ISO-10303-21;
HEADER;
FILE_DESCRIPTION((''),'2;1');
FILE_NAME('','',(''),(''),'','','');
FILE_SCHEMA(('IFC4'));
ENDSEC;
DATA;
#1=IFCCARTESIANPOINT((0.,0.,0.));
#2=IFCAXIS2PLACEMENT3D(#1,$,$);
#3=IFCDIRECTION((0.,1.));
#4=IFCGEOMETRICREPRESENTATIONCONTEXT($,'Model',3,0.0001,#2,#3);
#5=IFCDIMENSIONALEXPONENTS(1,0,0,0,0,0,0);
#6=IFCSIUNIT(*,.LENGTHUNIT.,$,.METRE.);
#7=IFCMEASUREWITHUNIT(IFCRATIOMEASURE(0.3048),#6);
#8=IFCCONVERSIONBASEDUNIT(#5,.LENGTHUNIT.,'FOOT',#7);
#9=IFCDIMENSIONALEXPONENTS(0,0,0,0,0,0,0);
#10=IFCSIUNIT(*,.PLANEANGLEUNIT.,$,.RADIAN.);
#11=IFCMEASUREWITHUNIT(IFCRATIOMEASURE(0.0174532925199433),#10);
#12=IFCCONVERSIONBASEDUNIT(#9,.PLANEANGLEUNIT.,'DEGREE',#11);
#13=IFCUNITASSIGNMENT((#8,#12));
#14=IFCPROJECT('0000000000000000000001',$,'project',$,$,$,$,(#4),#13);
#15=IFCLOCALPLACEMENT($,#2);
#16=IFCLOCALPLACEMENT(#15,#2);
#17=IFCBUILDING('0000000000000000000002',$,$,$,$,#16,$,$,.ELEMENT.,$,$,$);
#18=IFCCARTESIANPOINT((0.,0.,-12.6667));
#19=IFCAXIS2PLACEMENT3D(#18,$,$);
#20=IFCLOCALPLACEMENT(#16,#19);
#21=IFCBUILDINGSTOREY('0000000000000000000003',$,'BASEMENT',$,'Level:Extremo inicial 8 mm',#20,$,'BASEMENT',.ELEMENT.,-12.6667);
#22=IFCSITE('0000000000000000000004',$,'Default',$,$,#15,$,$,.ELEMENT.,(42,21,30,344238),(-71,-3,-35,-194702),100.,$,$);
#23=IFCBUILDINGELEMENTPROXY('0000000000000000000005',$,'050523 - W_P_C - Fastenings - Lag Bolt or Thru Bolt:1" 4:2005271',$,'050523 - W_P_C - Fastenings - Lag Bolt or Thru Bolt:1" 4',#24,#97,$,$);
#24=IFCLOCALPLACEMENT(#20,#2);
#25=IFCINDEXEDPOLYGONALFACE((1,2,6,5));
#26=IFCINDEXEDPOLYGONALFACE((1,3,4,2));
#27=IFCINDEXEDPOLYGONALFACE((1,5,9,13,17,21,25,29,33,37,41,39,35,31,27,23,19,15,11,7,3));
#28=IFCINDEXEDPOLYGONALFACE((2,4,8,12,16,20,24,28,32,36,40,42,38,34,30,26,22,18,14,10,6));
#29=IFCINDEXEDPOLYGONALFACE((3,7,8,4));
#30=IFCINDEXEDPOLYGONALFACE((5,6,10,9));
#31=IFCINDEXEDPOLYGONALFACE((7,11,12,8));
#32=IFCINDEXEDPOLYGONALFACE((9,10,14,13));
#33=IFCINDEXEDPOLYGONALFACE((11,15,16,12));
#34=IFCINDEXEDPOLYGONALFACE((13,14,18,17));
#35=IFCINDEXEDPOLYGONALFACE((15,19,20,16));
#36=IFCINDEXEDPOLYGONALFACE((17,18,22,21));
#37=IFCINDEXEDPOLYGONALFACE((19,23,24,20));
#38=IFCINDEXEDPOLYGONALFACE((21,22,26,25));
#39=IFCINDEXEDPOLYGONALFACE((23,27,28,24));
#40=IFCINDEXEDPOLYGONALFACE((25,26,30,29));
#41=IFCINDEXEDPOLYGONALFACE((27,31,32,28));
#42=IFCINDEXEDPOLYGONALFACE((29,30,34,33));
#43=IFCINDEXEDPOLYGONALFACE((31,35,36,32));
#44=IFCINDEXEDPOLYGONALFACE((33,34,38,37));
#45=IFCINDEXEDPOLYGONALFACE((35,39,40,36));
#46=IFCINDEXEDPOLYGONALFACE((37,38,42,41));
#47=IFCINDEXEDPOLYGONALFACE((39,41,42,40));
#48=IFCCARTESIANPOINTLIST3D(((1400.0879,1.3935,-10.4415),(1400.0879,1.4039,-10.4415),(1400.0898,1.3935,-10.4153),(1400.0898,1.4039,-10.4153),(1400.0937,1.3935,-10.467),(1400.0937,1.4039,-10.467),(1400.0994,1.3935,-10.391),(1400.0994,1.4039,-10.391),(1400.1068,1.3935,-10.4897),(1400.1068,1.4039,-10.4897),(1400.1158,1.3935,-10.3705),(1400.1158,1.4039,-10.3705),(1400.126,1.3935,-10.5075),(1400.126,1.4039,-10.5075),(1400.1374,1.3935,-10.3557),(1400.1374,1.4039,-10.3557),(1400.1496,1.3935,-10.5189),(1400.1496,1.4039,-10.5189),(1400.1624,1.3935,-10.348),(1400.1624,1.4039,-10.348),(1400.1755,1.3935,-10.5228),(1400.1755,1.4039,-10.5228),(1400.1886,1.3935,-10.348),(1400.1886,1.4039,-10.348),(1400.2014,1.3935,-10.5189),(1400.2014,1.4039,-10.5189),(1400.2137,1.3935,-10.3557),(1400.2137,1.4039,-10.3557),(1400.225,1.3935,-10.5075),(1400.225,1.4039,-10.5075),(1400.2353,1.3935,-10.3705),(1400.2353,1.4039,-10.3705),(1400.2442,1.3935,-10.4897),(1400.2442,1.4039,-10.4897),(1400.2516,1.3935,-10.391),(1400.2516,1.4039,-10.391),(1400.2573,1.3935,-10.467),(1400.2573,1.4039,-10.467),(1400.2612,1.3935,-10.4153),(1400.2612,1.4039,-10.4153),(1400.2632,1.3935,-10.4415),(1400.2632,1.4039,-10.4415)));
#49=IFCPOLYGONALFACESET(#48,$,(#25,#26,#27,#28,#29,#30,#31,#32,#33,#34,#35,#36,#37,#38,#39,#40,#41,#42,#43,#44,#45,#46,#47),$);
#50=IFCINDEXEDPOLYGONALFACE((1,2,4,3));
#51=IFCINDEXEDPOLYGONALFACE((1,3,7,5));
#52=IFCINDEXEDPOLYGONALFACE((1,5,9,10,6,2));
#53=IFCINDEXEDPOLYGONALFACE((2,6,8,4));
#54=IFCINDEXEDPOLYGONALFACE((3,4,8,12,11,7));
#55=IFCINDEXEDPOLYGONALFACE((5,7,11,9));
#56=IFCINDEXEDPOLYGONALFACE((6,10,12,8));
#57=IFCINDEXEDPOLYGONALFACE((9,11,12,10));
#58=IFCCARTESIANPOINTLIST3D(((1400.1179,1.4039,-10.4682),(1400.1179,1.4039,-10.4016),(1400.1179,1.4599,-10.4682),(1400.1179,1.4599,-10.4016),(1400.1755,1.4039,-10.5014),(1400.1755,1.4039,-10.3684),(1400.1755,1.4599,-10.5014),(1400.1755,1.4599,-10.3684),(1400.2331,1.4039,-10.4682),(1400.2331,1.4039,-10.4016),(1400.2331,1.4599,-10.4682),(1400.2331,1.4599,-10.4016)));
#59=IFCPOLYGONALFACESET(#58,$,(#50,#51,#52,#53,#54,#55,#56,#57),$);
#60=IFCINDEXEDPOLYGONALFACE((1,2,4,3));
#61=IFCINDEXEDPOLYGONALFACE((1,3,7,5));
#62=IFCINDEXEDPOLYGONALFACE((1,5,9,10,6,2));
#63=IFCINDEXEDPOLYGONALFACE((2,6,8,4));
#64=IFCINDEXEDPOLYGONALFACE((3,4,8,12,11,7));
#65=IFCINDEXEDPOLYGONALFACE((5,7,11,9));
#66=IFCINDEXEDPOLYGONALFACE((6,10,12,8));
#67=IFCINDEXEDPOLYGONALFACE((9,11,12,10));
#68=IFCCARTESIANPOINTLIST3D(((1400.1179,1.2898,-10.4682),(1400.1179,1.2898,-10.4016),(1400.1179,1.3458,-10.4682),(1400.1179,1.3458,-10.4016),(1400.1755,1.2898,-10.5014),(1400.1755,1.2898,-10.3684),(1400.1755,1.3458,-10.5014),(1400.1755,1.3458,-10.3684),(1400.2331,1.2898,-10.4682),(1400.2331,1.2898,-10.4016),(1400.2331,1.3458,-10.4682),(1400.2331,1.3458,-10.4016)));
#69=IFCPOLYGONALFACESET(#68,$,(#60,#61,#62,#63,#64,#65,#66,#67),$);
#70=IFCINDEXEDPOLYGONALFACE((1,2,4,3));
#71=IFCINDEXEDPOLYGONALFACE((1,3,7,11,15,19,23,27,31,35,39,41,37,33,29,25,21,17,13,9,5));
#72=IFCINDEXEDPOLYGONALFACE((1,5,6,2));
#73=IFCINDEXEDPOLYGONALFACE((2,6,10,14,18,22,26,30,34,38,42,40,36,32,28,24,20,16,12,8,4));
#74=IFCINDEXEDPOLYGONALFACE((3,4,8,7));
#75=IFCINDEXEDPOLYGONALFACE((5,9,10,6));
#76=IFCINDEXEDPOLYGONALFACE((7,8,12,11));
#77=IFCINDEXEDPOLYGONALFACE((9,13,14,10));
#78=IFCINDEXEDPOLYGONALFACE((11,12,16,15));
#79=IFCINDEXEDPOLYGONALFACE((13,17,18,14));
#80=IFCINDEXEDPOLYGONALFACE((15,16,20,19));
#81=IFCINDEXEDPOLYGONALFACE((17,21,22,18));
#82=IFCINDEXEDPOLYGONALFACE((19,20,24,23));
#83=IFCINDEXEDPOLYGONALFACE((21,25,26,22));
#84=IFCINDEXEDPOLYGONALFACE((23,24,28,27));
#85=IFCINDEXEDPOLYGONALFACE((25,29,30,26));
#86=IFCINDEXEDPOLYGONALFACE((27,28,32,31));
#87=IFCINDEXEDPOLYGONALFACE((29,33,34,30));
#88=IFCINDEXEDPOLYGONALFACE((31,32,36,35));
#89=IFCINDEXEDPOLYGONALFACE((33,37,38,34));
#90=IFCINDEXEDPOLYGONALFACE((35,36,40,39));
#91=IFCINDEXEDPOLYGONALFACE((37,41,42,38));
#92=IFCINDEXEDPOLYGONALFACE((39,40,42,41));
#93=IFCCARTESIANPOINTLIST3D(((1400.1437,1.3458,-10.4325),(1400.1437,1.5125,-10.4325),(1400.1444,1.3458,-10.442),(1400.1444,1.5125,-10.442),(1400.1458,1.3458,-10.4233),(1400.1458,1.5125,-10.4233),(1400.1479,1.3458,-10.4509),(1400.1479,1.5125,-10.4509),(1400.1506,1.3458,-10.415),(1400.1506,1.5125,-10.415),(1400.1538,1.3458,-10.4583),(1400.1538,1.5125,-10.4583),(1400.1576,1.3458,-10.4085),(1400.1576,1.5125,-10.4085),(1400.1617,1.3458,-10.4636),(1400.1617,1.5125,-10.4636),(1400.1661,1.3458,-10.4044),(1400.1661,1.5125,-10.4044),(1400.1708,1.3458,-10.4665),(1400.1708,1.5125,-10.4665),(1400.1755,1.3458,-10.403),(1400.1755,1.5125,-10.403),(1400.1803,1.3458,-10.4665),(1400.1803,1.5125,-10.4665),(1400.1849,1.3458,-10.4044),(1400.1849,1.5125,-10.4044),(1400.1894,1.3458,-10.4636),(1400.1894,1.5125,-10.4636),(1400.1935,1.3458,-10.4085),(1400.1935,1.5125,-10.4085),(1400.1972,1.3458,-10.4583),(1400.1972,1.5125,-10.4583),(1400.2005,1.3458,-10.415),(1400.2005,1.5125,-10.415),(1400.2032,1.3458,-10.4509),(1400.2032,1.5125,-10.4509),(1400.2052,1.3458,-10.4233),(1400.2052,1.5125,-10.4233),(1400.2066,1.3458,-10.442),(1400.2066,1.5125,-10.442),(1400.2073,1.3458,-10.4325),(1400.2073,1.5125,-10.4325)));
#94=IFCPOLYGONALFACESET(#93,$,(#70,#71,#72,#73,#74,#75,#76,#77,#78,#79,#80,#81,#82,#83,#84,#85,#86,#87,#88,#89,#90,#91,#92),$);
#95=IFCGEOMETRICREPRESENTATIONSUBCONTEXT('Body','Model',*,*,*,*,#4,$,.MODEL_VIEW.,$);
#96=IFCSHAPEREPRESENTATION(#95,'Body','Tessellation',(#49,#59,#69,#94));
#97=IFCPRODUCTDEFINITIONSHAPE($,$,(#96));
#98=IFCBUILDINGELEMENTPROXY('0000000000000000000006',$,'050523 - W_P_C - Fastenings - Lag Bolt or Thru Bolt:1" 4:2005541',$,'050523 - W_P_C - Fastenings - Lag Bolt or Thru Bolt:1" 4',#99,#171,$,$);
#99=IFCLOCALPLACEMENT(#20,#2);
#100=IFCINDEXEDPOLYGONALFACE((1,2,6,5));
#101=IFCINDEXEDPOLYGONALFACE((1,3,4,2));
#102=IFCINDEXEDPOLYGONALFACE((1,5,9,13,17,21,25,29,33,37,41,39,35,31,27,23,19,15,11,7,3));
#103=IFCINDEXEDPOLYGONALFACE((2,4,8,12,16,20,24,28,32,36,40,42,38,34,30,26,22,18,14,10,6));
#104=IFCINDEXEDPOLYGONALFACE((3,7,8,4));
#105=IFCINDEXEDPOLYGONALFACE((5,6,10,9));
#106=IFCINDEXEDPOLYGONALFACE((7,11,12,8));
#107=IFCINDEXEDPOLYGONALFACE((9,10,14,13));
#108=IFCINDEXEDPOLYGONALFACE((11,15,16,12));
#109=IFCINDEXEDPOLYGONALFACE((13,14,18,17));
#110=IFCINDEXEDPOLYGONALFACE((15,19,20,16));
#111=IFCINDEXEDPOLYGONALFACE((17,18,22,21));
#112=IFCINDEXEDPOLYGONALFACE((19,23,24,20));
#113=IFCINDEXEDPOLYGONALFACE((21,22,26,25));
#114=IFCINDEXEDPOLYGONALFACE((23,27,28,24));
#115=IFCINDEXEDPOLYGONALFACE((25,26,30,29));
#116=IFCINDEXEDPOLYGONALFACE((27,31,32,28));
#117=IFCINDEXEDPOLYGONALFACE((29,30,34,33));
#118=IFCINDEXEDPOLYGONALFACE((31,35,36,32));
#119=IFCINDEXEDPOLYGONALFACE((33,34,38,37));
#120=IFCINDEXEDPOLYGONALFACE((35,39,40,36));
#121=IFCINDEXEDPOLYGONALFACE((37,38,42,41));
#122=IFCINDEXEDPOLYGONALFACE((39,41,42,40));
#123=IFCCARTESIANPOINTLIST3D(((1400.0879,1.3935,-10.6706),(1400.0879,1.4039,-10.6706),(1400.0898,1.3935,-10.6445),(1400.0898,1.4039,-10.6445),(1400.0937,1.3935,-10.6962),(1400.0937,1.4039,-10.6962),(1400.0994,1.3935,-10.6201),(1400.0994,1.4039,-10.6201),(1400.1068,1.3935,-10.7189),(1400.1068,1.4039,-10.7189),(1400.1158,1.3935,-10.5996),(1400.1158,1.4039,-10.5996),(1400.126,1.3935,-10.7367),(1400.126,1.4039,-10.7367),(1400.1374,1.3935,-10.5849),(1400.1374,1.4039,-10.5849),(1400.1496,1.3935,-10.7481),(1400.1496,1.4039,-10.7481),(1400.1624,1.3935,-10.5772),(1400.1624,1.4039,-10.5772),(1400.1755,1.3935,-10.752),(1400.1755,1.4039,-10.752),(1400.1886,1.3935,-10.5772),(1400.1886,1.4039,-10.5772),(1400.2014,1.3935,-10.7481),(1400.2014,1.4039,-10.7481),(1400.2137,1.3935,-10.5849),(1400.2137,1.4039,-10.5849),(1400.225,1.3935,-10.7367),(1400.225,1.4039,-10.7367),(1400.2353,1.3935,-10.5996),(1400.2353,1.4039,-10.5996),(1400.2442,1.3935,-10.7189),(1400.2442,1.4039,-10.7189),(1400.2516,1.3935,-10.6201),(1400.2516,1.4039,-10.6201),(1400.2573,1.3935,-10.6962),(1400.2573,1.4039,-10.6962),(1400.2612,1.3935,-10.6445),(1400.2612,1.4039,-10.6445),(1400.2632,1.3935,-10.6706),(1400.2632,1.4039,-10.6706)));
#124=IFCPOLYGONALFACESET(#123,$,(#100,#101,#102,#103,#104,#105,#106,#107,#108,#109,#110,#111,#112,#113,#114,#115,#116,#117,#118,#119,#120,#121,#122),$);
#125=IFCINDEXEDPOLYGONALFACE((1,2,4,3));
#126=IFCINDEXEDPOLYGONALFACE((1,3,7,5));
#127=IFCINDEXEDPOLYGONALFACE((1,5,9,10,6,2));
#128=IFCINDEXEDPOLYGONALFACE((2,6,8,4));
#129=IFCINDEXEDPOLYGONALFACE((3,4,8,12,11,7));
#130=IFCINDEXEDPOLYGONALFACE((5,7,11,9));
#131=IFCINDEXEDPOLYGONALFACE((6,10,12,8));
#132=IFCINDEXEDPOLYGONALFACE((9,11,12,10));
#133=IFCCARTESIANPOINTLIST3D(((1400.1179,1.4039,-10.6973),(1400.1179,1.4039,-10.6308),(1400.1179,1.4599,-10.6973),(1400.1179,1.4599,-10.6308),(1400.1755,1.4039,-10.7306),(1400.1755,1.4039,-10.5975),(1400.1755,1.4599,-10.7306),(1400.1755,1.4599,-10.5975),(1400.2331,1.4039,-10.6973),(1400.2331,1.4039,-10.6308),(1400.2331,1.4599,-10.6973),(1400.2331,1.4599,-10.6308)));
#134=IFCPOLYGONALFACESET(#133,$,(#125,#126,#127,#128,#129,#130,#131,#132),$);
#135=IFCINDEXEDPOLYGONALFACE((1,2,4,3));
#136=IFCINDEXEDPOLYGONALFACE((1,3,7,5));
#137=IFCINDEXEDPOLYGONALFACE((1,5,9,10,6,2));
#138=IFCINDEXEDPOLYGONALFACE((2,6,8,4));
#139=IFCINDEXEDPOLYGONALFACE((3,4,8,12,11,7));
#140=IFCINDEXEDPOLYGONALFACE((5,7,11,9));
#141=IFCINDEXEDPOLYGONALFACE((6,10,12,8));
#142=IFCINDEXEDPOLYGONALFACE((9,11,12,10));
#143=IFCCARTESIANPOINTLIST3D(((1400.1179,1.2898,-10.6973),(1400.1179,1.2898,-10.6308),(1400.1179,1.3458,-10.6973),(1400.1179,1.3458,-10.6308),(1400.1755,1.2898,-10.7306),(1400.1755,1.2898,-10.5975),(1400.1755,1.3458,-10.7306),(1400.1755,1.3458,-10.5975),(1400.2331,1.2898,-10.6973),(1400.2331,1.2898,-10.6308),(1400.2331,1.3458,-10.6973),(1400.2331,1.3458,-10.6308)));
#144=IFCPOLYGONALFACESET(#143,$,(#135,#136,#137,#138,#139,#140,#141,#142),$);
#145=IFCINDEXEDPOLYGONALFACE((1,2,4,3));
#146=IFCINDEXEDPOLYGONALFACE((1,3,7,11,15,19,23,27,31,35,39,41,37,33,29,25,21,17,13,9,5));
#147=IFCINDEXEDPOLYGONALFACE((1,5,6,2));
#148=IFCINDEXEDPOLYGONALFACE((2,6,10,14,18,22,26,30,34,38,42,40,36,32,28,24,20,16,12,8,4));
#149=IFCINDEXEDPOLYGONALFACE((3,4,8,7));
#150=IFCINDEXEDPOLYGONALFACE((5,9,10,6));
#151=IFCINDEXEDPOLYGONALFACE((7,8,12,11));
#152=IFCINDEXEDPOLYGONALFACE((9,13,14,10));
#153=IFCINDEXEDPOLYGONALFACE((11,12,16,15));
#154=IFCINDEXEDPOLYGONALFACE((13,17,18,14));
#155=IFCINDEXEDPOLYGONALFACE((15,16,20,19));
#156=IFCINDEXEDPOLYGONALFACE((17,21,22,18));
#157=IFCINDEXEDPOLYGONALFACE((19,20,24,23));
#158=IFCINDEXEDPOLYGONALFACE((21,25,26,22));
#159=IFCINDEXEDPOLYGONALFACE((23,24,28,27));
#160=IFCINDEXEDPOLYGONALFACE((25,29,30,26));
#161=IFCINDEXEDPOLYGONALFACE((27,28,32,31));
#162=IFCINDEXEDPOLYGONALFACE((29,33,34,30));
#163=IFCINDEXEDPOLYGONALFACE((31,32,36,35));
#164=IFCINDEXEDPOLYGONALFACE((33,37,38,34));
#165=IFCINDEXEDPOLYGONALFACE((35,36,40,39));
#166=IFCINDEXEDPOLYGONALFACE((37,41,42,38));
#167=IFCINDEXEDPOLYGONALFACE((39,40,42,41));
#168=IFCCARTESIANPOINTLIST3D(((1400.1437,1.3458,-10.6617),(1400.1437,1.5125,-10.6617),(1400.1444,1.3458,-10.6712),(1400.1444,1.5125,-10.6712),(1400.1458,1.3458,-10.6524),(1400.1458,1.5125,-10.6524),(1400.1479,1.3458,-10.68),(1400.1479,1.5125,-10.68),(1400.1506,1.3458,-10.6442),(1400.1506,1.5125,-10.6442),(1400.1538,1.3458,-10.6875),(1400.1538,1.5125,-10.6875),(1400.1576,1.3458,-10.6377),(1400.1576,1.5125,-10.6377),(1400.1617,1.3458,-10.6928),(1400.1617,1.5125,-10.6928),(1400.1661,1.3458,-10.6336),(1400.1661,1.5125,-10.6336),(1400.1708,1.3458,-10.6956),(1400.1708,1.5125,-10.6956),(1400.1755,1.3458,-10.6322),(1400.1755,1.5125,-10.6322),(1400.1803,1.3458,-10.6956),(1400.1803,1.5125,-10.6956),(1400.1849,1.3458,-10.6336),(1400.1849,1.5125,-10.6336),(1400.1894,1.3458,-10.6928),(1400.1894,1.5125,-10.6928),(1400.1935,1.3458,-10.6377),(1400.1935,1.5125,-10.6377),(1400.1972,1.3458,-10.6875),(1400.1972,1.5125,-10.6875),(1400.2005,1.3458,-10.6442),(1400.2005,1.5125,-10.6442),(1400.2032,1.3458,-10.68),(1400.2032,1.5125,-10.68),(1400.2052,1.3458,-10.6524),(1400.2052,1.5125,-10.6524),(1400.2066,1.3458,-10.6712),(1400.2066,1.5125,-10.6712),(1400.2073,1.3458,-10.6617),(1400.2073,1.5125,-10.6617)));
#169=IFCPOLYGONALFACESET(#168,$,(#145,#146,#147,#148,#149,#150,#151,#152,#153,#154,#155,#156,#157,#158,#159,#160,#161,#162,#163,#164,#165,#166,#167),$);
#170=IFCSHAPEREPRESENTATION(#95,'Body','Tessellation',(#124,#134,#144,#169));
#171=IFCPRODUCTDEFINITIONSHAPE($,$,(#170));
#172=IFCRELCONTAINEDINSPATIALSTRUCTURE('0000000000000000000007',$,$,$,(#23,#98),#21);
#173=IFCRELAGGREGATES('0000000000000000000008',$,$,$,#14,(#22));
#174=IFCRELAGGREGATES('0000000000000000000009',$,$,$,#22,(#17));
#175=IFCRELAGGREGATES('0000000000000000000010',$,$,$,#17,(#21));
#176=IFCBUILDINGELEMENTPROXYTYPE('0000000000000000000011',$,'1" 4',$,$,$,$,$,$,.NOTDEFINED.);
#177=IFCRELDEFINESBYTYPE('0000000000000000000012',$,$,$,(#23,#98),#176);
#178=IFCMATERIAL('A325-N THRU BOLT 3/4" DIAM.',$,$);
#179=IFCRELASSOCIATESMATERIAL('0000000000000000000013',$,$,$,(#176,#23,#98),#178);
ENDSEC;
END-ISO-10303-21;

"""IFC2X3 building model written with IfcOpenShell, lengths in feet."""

from ifc_helpers import new_model, entity, si_unit, converted_unit, direction, frame, frame_2d, origin, place, context, subcontext, project, spatial, polyline, circle, outline, extrude, source, transform, mapped, material, type_object, type_shapes, element, save


model = new_model("IFC2X3")

# Units and contexts
model_context = context("Model", 3, precision=0.0001, world=origin(), true_north=direction((0.0, 1.0)))
body_context = subcontext(model_context, "Body", "Model", "MODEL_VIEW")
ifc_project = project(units=[converted_unit("LENGTHUNIT", "FOOT", entity("IfcRatioMeasure", 0.3048), si_unit("LENGTHUNIT", "METRE"), dimensions=[1, 0, 0, 0, 0, 0, 0]), converted_unit("PLANEANGLEUNIT", "DEGREE", entity("IfcRatioMeasure", 0.0174532925199433), si_unit("PLANEANGLEUNIT", "RADIAN"), dimensions=[0, 0, 0, 0, 0, 0, 0])], contexts=[model_context])

# Site, building, storey
site_placement = place(None, origin())
site = spatial("IfcSite", under=ifc_project, at=site_placement, Name="Default", CompositionType="ELEMENT", RefLatitude=(42, 21, 30, 344238), RefLongitude=(-71, -3, -35, -194702), RefElevation=100.0)
building_placement = place(site_placement, origin())
building = spatial("IfcBuilding", under=site, at=building_placement, CompositionType="ELEMENT")
storey_placement = place(building_placement, frame((0.0, 0.0, -12.6667)))
storey = spatial("IfcBuildingStorey", under=building, at=storey_placement, Name="BASEMENT", ObjectType="Level:Extremo inicial 8 mm", LongName="BASEMENT", CompositionType="ELEMENT", Elevation=-12.6667)

# Building element proxies
ifc_material_1 = material(Name="A325-N THRU BOLT 3/4\" DIAM.")
building_element_proxy_type_1 = type_object("IfcBuildingElementProxyType", Name="1\" 4", PredefinedType="NOTDEFINED", material=ifc_material_1)
shared_shape_1 = source(origin(), body_context, "Body", "SweptSolid", [
    extrude(circle(Radius=0.0879, at=frame_2d((0.0, 0.0), x_axis=(1.0, 0.0))), frame((0.0, 0.0, -0.0581), z_axis=(0.0, 0.0, 1.0), x_axis=(0.0, -1.0, 0.0)), (0.0, 0.0, 1.0), 0.0104),
    extrude(outline(polyline([(-0.0333, -0.0576), (0.0333, -0.0576), (0.0665, 0.0), (0.0333, 0.0576), (-0.0333, 0.0576), (-0.0665, 0.0), (-0.0333, -0.0576)])), frame((0.0, 0.0, -0.1141), z_axis=(0.0, 0.0, 1.0), x_axis=(0.866025, -0.5, 0.0)), (0.0, 0.0, 1.0), 0.056),
    extrude(outline(polyline([(-0.0333, -0.0576), (0.0333, -0.0576), (0.0665, 0.0), (0.0333, 0.0576), (-0.0333, 0.0576), (-0.0665, 0.0), (-0.0333, -0.0576)])), frame((0.0, 0.0, 0.0), z_axis=(0.0, 0.0, 1.0), x_axis=(0.0, -1.0, 0.0)), (0.0, 0.0, 1.0), 0.056),
    extrude(circle(Radius=0.0319, at=frame_2d((0.0, 0.0), x_axis=(1.0, 0.0))), frame((0.0, 0.0, -0.1667), z_axis=(0.0, 0.0, 1.0), x_axis=(0.0, 1.0, 0.0)), (0.0, 0.0, 1.0), 0.1667),
])
type_shapes(building_element_proxy_type_1, [shared_shape_1])
for number, where, z_axis, x_axis, name in (
    (1, (1400.1755, 1.3458, -10.4349), (0.0, -1.0, 0.0), (1.0, 0.0, 0.0), "050523 - W_P_C - Fastenings - Lag Bolt or Thru Bolt:1\" 4:2005271"),
    (2, (1400.1755, 1.3458, -10.6641), (0.0, -1.0, 0.0), (1.0, 0.0, 0.0), "050523 - W_P_C - Fastenings - Lag Bolt or Thru Bolt:1\" 4:2005541"),
):
    element("IfcBuildingElementProxy", number, at=place(storey_placement, frame(where, z_axis=z_axis, x_axis=x_axis)), inside=storey, type_object=building_element_proxy_type_1, material=ifc_material_1, Name=name, ObjectType="050523 - W_P_C - Fastenings - Lag Bolt or Thru Bolt:1\" 4", context=body_context, shape_type="MappedRepresentation", body=[
        mapped(shared_shape_1, transform((0.0, 0.0, 0.0), scale=1.0)),
    ])

save(model, "model.ifc")
